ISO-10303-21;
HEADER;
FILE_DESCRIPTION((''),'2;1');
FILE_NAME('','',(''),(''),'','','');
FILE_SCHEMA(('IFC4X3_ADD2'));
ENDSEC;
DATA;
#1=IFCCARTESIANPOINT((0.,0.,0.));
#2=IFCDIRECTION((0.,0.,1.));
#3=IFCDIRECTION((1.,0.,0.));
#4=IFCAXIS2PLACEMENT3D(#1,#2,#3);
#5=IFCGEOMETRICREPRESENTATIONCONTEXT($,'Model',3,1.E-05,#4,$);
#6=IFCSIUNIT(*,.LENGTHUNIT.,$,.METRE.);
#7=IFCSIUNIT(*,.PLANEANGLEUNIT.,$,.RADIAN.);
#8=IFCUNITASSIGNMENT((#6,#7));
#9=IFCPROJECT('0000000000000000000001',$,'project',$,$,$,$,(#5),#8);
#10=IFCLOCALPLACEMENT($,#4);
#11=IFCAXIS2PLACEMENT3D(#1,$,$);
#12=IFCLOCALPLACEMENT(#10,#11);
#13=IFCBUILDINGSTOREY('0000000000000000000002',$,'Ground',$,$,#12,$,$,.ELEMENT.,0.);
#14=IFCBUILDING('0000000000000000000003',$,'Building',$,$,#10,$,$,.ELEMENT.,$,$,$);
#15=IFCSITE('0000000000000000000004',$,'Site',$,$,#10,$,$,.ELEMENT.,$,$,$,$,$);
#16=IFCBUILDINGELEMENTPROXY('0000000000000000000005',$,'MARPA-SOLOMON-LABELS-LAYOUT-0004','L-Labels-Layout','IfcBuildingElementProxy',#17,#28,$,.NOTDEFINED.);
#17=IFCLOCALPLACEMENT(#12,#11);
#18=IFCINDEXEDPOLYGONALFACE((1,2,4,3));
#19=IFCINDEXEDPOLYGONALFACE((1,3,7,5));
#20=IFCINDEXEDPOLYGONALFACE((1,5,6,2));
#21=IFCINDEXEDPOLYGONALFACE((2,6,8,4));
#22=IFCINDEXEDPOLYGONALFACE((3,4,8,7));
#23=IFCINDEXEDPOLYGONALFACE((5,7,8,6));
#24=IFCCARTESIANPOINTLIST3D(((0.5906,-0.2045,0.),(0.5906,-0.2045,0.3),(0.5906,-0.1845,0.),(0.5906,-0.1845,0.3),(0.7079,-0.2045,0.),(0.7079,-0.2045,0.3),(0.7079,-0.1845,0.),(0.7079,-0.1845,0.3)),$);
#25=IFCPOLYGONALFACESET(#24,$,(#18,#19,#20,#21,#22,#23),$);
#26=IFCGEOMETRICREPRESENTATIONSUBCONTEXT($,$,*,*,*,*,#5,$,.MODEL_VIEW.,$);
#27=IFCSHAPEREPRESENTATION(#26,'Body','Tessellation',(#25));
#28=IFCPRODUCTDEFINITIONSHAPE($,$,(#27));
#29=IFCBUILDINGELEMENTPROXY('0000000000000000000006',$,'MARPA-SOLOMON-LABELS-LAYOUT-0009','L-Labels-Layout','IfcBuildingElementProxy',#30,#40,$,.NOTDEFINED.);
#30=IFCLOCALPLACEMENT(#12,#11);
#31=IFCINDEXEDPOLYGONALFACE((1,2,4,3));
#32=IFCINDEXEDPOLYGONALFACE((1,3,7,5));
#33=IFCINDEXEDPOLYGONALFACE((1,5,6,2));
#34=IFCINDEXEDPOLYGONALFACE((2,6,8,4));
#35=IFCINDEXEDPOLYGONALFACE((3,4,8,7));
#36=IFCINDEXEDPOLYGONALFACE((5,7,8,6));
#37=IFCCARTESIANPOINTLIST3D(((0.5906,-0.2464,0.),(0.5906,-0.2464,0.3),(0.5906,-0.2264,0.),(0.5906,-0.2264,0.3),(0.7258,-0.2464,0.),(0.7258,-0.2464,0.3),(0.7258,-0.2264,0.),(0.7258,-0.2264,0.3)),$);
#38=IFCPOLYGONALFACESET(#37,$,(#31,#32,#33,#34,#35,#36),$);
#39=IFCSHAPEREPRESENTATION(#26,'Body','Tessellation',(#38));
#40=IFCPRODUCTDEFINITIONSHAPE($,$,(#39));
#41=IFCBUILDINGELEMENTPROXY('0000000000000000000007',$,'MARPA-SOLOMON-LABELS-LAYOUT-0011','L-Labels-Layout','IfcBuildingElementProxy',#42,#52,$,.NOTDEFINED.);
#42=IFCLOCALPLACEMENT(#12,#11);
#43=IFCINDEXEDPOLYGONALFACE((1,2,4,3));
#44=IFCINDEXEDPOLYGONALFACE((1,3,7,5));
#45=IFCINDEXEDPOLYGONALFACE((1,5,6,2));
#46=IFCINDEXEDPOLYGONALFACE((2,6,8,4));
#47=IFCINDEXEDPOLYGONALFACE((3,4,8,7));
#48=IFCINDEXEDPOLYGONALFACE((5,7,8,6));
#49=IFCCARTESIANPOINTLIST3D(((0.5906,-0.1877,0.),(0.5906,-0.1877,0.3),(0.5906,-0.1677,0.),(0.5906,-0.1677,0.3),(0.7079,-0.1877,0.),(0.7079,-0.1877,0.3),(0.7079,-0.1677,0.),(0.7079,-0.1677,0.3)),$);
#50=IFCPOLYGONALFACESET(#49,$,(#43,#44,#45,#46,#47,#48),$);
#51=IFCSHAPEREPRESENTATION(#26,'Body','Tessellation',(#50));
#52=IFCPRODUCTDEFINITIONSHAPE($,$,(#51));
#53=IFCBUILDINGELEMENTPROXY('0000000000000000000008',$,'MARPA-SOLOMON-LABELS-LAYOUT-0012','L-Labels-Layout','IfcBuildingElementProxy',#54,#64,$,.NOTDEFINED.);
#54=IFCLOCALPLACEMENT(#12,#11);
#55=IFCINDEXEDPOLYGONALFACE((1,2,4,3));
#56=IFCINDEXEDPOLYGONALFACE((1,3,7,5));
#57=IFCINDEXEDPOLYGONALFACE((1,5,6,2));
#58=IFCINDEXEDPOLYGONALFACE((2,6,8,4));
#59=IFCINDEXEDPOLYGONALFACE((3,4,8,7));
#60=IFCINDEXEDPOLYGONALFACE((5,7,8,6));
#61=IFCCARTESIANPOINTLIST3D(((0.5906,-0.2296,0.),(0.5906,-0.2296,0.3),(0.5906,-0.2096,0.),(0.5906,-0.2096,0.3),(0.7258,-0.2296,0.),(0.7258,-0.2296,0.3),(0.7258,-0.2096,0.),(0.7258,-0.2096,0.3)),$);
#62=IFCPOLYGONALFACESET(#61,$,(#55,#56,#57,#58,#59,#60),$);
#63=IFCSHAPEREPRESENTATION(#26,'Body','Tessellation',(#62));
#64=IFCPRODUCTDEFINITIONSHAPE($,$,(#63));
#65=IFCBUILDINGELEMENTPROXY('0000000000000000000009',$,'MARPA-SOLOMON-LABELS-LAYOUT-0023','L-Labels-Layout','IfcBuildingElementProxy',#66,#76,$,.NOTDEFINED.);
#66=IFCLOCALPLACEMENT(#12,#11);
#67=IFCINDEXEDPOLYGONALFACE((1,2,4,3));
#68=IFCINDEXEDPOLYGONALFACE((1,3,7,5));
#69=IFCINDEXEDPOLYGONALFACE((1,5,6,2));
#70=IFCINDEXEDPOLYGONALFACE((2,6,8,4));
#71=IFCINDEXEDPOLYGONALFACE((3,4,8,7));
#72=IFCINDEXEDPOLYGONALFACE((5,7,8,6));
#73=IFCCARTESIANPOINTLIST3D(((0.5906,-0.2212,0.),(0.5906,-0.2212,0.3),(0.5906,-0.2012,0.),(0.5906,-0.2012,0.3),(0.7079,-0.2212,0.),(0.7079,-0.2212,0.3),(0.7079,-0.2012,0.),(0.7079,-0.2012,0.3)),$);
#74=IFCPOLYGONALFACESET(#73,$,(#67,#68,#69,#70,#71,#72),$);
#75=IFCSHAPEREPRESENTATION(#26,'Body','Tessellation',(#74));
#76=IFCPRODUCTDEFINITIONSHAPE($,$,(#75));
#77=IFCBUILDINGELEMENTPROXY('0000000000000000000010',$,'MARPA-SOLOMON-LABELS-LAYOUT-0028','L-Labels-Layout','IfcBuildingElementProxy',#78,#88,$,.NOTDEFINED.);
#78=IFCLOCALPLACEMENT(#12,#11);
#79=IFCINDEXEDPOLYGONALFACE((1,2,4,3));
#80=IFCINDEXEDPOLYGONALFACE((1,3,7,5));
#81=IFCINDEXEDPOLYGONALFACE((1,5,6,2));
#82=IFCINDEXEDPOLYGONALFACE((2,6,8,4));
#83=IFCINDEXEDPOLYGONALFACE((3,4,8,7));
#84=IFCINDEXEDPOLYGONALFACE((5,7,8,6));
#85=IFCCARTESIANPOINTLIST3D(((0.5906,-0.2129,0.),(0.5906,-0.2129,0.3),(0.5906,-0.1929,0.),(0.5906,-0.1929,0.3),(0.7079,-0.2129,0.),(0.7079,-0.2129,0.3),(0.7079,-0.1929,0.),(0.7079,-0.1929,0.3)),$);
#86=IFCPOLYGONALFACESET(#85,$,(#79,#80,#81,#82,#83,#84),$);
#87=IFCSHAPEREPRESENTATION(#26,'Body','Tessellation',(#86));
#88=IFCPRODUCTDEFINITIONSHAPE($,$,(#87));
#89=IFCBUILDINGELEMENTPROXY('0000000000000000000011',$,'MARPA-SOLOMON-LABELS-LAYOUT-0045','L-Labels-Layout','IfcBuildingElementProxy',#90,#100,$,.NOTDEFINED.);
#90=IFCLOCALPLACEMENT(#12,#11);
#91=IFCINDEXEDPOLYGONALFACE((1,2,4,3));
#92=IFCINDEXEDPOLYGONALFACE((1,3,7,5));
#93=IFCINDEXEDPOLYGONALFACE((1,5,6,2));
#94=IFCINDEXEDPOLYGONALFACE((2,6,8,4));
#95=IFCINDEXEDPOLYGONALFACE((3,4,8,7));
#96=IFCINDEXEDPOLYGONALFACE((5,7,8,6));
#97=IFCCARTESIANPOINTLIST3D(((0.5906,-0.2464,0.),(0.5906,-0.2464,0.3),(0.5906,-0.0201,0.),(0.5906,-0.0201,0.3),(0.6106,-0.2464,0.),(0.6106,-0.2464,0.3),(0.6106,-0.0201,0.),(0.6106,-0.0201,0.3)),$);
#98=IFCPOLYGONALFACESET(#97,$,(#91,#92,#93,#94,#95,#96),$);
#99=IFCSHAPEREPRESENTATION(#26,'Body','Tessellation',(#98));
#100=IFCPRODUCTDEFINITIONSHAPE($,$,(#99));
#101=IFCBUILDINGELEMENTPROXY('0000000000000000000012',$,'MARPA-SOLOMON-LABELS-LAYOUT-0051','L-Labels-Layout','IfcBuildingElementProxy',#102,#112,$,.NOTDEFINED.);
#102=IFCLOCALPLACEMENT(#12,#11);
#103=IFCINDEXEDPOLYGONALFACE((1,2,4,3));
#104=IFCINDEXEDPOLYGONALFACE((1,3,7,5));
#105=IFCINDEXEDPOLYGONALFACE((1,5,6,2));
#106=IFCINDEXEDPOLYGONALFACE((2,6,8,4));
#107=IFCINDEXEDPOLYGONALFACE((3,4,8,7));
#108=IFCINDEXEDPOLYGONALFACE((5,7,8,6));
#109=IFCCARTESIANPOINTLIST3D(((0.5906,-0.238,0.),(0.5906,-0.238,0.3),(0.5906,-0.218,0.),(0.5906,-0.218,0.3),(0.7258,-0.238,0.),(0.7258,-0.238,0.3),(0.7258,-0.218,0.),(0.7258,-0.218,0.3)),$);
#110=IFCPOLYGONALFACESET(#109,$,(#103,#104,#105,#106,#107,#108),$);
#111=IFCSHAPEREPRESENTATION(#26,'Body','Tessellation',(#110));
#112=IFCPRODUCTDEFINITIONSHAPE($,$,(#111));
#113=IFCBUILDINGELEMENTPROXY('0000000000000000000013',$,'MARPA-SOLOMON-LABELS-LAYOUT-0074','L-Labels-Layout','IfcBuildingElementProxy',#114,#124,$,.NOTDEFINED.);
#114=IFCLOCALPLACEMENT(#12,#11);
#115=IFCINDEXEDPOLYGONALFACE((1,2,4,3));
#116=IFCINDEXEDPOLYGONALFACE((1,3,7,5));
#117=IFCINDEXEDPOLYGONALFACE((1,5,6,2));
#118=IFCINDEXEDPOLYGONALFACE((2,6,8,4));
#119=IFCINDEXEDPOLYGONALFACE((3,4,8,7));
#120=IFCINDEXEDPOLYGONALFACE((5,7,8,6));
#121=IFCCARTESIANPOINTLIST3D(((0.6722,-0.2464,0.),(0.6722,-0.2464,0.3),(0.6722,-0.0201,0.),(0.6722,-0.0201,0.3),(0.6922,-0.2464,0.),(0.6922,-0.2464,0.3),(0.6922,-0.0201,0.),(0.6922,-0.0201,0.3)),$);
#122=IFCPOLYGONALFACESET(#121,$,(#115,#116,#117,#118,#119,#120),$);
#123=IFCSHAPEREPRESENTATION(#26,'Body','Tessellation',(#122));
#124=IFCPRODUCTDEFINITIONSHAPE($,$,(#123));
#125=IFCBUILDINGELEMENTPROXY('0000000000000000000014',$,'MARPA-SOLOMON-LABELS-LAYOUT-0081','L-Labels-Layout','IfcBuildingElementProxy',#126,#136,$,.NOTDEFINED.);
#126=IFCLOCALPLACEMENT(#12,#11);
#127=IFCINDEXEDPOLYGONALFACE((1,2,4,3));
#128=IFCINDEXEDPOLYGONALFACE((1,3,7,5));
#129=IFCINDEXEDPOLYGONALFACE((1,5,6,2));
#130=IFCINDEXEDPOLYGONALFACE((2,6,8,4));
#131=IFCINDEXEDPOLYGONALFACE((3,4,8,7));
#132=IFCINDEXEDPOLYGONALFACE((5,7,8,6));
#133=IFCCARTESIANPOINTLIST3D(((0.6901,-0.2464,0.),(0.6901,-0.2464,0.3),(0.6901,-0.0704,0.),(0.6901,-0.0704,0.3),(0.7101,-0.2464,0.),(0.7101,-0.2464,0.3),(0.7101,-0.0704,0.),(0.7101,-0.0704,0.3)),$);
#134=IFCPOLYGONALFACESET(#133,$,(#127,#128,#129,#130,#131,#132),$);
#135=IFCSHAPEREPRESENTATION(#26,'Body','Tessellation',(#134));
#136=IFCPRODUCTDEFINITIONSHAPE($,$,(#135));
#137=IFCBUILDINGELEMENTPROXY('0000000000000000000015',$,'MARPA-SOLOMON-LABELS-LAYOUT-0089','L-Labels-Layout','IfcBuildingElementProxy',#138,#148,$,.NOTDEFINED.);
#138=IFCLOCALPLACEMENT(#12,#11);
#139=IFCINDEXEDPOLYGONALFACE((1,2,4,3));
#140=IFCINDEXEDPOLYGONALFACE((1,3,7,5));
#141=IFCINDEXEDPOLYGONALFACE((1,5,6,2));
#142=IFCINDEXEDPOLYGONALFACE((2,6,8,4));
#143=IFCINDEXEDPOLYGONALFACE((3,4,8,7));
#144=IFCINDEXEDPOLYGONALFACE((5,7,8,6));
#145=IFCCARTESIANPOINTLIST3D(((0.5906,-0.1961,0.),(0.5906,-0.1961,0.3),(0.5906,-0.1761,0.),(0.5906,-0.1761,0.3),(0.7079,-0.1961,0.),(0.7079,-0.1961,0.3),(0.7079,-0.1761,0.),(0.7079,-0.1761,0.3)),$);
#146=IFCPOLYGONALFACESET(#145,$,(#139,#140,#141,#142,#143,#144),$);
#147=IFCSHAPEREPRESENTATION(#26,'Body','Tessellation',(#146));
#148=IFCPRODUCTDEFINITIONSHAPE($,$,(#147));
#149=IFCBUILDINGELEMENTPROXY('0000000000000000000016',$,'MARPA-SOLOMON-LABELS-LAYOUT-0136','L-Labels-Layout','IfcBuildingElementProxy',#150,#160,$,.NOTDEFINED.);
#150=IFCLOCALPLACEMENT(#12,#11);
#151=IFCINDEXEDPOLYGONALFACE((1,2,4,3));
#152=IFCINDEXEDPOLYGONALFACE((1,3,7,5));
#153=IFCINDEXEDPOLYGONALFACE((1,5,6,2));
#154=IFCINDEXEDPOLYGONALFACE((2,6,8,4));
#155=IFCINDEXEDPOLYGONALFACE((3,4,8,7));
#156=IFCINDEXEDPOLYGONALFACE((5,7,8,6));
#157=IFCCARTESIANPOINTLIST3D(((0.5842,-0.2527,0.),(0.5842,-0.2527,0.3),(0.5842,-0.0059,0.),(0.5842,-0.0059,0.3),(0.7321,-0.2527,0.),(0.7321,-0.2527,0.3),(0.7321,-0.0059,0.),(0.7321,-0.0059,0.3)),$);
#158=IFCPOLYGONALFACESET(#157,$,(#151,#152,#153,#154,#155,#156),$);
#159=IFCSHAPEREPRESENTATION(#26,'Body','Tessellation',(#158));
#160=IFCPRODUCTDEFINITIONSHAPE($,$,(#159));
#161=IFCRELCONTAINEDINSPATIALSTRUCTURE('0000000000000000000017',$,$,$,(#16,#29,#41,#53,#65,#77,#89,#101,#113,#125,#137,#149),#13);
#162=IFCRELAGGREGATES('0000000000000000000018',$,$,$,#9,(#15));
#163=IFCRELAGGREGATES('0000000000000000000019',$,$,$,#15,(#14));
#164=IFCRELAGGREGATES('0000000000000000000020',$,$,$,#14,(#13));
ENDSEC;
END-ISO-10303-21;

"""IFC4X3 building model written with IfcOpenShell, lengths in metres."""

from ifc_helpers import new_model, si_unit, frame, frame_2d, origin, origin_with_axes, place, context, subcontext, project, spatial, polyline, rectangle, outline, extrude, element, save


model = new_model("IFC4X3")

# Units and contexts
model_context = context("Model", 3, precision=1e-05, world=origin_with_axes())
sub_context = subcontext(model_context, None, None, "MODEL_VIEW")
ifc_project = project(units=[si_unit("LENGTHUNIT", "METRE"), si_unit("PLANEANGLEUNIT", "RADIAN")], contexts=[model_context])

# Site, building, storey
placement = place(None, origin_with_axes())
site = spatial("IfcSite", under=ifc_project, at=placement, Name="Site", CompositionType="ELEMENT")
building = spatial("IfcBuilding", under=site, at=placement, Name="Building", CompositionType="ELEMENT")
storey_placement = place(placement, origin())
storey = spatial("IfcBuildingStorey", under=building, at=storey_placement, Name="Ground", CompositionType="ELEMENT", Elevation=0.0)

# Building element proxies
proxy_1_placement = place(placement, frame((0.5906, -0.2045, 0.0)))
element("IfcBuildingElementProxy", 1, at=proxy_1_placement, inside=storey, Name="MARPA-SOLOMON-LABELS-LAYOUT-0004", Description="L-Labels-Layout", ObjectType="IfcBuildingElementProxy", PredefinedType="NOTDEFINED", context=sub_context, shape_type="SweptSolid", body=[
    extrude(rectangle(XDim=0.1174, YDim=0.02, at=frame_2d((0.0587, 0.01))), origin(), (0.0, 0.0, 1.0), 0.3),
])
proxy_2_placement = place(placement, frame((0.5906, -0.2464, 0.0)))
element("IfcBuildingElementProxy", 2, at=proxy_2_placement, inside=storey, Name="MARPA-SOLOMON-LABELS-LAYOUT-0009", Description="L-Labels-Layout", ObjectType="IfcBuildingElementProxy", PredefinedType="NOTDEFINED", context=sub_context, shape_type="SweptSolid", body=[
    extrude(rectangle(XDim=0.1352, YDim=0.02, at=frame_2d((0.0676, 0.01))), origin(), (0.0, 0.0, 1.0), 0.3),
])
proxy_3_placement = place(placement, frame((0.5906, -0.1877, 0.0)))
element("IfcBuildingElementProxy", 3, at=proxy_3_placement, inside=storey, Name="MARPA-SOLOMON-LABELS-LAYOUT-0011", Description="L-Labels-Layout", ObjectType="IfcBuildingElementProxy", PredefinedType="NOTDEFINED", context=sub_context, shape_type="SweptSolid", body=[
    extrude(rectangle(XDim=0.1174, YDim=0.02, at=frame_2d((0.0587, 0.01))), origin(), (0.0, 0.0, 1.0), 0.3),
])
proxy_4_placement = place(placement, frame((0.5906, -0.2296, 0.0)))
element("IfcBuildingElementProxy", 4, at=proxy_4_placement, inside=storey, Name="MARPA-SOLOMON-LABELS-LAYOUT-0012", Description="L-Labels-Layout", ObjectType="IfcBuildingElementProxy", PredefinedType="NOTDEFINED", context=sub_context, shape_type="SweptSolid", body=[
    extrude(rectangle(XDim=0.1352, YDim=0.02, at=frame_2d((0.0676, 0.01))), origin(), (0.0, 0.0, 1.0), 0.3),
])
for number, where, name in (
    (5, (0.5906, -0.2212, 0.0), "MARPA-SOLOMON-LABELS-LAYOUT-0023"),
    (6, (0.5906, -0.2129, 0.0), "MARPA-SOLOMON-LABELS-LAYOUT-0028"),
):
    element("IfcBuildingElementProxy", number, at=place(placement, frame(where)), inside=storey, Name=name, Description="L-Labels-Layout", ObjectType="IfcBuildingElementProxy", PredefinedType="NOTDEFINED", context=sub_context, shape_type="SweptSolid", body=[
        extrude(rectangle(XDim=0.1174, YDim=0.02, at=frame_2d((0.0587, 0.01))), origin(), (0.0, 0.0, 1.0), 0.3),
    ])
proxy_5_placement = place(placement, frame((0.5906, -0.2464, 0.0)))
element("IfcBuildingElementProxy", 7, at=proxy_5_placement, inside=storey, Name="MARPA-SOLOMON-LABELS-LAYOUT-0045", Description="L-Labels-Layout", ObjectType="IfcBuildingElementProxy", PredefinedType="NOTDEFINED", context=sub_context, shape_type="SweptSolid", body=[
    extrude(rectangle(XDim=0.02, YDim=0.2263, at=frame_2d((0.01, 0.1132))), origin(), (0.0, 0.0, 1.0), 0.3),
])
for number, where, name in (
    (8, (0.5906, -0.238, 0.0), "MARPA-SOLOMON-LABELS-LAYOUT-0051"),
):
    element("IfcBuildingElementProxy", number, at=place(placement, frame(where)), inside=storey, Name=name, Description="L-Labels-Layout", ObjectType="IfcBuildingElementProxy", PredefinedType="NOTDEFINED", context=sub_context, shape_type="SweptSolid", body=[
        extrude(rectangle(XDim=0.1352, YDim=0.02, at=frame_2d((0.0676, 0.01))), origin(), (0.0, 0.0, 1.0), 0.3),
    ])
for number, where, name in (
    (9, (0.6722, -0.2464, 0.0), "MARPA-SOLOMON-LABELS-LAYOUT-0074"),
):
    element("IfcBuildingElementProxy", number, at=place(placement, frame(where)), inside=storey, Name=name, Description="L-Labels-Layout", ObjectType="IfcBuildingElementProxy", PredefinedType="NOTDEFINED", context=sub_context, shape_type="SweptSolid", body=[
        extrude(rectangle(XDim=0.02, YDim=0.2263, at=frame_2d((0.01, 0.1132))), origin(), (0.0, 0.0, 1.0), 0.3),
    ])
proxy_6_placement = place(placement, frame((0.6901, -0.2464, 0.0)))
element("IfcBuildingElementProxy", 10, at=proxy_6_placement, inside=storey, Name="MARPA-SOLOMON-LABELS-LAYOUT-0081", Description="L-Labels-Layout", ObjectType="IfcBuildingElementProxy", PredefinedType="NOTDEFINED", context=sub_context, shape_type="SweptSolid", body=[
    extrude(rectangle(XDim=0.02, YDim=0.176, at=frame_2d((0.01, 0.088))), origin(), (0.0, 0.0, 1.0), 0.3),
])
for number, where, name in (
    (11, (0.5906, -0.1961, 0.0), "MARPA-SOLOMON-LABELS-LAYOUT-0089"),
):
    element("IfcBuildingElementProxy", number, at=place(placement, frame(where)), inside=storey, Name=name, Description="L-Labels-Layout", ObjectType="IfcBuildingElementProxy", PredefinedType="NOTDEFINED", context=sub_context, shape_type="SweptSolid", body=[
        extrude(rectangle(XDim=0.1174, YDim=0.02, at=frame_2d((0.0587, 0.01))), origin(), (0.0, 0.0, 1.0), 0.3),
    ])
proxy_7_placement = place(placement, frame((0.5842, -0.2527, 0.0)))
element("IfcBuildingElementProxy", 12, at=proxy_7_placement, inside=storey, Name="MARPA-SOLOMON-LABELS-LAYOUT-0136", Description="L-Labels-Layout", ObjectType="IfcBuildingElementProxy", PredefinedType="NOTDEFINED", context=sub_context, shape_type="SweptSolid", body=[
    extrude(outline(polyline([(0.0, 0.2468), (0.1479, 0.2468), (0.1479, 0.0), (0.0, 0.0), (0.0, 0.2468)])), origin(), (0.0, 0.0, 1.0), 0.3),
])

save(model, "model.ifc")
